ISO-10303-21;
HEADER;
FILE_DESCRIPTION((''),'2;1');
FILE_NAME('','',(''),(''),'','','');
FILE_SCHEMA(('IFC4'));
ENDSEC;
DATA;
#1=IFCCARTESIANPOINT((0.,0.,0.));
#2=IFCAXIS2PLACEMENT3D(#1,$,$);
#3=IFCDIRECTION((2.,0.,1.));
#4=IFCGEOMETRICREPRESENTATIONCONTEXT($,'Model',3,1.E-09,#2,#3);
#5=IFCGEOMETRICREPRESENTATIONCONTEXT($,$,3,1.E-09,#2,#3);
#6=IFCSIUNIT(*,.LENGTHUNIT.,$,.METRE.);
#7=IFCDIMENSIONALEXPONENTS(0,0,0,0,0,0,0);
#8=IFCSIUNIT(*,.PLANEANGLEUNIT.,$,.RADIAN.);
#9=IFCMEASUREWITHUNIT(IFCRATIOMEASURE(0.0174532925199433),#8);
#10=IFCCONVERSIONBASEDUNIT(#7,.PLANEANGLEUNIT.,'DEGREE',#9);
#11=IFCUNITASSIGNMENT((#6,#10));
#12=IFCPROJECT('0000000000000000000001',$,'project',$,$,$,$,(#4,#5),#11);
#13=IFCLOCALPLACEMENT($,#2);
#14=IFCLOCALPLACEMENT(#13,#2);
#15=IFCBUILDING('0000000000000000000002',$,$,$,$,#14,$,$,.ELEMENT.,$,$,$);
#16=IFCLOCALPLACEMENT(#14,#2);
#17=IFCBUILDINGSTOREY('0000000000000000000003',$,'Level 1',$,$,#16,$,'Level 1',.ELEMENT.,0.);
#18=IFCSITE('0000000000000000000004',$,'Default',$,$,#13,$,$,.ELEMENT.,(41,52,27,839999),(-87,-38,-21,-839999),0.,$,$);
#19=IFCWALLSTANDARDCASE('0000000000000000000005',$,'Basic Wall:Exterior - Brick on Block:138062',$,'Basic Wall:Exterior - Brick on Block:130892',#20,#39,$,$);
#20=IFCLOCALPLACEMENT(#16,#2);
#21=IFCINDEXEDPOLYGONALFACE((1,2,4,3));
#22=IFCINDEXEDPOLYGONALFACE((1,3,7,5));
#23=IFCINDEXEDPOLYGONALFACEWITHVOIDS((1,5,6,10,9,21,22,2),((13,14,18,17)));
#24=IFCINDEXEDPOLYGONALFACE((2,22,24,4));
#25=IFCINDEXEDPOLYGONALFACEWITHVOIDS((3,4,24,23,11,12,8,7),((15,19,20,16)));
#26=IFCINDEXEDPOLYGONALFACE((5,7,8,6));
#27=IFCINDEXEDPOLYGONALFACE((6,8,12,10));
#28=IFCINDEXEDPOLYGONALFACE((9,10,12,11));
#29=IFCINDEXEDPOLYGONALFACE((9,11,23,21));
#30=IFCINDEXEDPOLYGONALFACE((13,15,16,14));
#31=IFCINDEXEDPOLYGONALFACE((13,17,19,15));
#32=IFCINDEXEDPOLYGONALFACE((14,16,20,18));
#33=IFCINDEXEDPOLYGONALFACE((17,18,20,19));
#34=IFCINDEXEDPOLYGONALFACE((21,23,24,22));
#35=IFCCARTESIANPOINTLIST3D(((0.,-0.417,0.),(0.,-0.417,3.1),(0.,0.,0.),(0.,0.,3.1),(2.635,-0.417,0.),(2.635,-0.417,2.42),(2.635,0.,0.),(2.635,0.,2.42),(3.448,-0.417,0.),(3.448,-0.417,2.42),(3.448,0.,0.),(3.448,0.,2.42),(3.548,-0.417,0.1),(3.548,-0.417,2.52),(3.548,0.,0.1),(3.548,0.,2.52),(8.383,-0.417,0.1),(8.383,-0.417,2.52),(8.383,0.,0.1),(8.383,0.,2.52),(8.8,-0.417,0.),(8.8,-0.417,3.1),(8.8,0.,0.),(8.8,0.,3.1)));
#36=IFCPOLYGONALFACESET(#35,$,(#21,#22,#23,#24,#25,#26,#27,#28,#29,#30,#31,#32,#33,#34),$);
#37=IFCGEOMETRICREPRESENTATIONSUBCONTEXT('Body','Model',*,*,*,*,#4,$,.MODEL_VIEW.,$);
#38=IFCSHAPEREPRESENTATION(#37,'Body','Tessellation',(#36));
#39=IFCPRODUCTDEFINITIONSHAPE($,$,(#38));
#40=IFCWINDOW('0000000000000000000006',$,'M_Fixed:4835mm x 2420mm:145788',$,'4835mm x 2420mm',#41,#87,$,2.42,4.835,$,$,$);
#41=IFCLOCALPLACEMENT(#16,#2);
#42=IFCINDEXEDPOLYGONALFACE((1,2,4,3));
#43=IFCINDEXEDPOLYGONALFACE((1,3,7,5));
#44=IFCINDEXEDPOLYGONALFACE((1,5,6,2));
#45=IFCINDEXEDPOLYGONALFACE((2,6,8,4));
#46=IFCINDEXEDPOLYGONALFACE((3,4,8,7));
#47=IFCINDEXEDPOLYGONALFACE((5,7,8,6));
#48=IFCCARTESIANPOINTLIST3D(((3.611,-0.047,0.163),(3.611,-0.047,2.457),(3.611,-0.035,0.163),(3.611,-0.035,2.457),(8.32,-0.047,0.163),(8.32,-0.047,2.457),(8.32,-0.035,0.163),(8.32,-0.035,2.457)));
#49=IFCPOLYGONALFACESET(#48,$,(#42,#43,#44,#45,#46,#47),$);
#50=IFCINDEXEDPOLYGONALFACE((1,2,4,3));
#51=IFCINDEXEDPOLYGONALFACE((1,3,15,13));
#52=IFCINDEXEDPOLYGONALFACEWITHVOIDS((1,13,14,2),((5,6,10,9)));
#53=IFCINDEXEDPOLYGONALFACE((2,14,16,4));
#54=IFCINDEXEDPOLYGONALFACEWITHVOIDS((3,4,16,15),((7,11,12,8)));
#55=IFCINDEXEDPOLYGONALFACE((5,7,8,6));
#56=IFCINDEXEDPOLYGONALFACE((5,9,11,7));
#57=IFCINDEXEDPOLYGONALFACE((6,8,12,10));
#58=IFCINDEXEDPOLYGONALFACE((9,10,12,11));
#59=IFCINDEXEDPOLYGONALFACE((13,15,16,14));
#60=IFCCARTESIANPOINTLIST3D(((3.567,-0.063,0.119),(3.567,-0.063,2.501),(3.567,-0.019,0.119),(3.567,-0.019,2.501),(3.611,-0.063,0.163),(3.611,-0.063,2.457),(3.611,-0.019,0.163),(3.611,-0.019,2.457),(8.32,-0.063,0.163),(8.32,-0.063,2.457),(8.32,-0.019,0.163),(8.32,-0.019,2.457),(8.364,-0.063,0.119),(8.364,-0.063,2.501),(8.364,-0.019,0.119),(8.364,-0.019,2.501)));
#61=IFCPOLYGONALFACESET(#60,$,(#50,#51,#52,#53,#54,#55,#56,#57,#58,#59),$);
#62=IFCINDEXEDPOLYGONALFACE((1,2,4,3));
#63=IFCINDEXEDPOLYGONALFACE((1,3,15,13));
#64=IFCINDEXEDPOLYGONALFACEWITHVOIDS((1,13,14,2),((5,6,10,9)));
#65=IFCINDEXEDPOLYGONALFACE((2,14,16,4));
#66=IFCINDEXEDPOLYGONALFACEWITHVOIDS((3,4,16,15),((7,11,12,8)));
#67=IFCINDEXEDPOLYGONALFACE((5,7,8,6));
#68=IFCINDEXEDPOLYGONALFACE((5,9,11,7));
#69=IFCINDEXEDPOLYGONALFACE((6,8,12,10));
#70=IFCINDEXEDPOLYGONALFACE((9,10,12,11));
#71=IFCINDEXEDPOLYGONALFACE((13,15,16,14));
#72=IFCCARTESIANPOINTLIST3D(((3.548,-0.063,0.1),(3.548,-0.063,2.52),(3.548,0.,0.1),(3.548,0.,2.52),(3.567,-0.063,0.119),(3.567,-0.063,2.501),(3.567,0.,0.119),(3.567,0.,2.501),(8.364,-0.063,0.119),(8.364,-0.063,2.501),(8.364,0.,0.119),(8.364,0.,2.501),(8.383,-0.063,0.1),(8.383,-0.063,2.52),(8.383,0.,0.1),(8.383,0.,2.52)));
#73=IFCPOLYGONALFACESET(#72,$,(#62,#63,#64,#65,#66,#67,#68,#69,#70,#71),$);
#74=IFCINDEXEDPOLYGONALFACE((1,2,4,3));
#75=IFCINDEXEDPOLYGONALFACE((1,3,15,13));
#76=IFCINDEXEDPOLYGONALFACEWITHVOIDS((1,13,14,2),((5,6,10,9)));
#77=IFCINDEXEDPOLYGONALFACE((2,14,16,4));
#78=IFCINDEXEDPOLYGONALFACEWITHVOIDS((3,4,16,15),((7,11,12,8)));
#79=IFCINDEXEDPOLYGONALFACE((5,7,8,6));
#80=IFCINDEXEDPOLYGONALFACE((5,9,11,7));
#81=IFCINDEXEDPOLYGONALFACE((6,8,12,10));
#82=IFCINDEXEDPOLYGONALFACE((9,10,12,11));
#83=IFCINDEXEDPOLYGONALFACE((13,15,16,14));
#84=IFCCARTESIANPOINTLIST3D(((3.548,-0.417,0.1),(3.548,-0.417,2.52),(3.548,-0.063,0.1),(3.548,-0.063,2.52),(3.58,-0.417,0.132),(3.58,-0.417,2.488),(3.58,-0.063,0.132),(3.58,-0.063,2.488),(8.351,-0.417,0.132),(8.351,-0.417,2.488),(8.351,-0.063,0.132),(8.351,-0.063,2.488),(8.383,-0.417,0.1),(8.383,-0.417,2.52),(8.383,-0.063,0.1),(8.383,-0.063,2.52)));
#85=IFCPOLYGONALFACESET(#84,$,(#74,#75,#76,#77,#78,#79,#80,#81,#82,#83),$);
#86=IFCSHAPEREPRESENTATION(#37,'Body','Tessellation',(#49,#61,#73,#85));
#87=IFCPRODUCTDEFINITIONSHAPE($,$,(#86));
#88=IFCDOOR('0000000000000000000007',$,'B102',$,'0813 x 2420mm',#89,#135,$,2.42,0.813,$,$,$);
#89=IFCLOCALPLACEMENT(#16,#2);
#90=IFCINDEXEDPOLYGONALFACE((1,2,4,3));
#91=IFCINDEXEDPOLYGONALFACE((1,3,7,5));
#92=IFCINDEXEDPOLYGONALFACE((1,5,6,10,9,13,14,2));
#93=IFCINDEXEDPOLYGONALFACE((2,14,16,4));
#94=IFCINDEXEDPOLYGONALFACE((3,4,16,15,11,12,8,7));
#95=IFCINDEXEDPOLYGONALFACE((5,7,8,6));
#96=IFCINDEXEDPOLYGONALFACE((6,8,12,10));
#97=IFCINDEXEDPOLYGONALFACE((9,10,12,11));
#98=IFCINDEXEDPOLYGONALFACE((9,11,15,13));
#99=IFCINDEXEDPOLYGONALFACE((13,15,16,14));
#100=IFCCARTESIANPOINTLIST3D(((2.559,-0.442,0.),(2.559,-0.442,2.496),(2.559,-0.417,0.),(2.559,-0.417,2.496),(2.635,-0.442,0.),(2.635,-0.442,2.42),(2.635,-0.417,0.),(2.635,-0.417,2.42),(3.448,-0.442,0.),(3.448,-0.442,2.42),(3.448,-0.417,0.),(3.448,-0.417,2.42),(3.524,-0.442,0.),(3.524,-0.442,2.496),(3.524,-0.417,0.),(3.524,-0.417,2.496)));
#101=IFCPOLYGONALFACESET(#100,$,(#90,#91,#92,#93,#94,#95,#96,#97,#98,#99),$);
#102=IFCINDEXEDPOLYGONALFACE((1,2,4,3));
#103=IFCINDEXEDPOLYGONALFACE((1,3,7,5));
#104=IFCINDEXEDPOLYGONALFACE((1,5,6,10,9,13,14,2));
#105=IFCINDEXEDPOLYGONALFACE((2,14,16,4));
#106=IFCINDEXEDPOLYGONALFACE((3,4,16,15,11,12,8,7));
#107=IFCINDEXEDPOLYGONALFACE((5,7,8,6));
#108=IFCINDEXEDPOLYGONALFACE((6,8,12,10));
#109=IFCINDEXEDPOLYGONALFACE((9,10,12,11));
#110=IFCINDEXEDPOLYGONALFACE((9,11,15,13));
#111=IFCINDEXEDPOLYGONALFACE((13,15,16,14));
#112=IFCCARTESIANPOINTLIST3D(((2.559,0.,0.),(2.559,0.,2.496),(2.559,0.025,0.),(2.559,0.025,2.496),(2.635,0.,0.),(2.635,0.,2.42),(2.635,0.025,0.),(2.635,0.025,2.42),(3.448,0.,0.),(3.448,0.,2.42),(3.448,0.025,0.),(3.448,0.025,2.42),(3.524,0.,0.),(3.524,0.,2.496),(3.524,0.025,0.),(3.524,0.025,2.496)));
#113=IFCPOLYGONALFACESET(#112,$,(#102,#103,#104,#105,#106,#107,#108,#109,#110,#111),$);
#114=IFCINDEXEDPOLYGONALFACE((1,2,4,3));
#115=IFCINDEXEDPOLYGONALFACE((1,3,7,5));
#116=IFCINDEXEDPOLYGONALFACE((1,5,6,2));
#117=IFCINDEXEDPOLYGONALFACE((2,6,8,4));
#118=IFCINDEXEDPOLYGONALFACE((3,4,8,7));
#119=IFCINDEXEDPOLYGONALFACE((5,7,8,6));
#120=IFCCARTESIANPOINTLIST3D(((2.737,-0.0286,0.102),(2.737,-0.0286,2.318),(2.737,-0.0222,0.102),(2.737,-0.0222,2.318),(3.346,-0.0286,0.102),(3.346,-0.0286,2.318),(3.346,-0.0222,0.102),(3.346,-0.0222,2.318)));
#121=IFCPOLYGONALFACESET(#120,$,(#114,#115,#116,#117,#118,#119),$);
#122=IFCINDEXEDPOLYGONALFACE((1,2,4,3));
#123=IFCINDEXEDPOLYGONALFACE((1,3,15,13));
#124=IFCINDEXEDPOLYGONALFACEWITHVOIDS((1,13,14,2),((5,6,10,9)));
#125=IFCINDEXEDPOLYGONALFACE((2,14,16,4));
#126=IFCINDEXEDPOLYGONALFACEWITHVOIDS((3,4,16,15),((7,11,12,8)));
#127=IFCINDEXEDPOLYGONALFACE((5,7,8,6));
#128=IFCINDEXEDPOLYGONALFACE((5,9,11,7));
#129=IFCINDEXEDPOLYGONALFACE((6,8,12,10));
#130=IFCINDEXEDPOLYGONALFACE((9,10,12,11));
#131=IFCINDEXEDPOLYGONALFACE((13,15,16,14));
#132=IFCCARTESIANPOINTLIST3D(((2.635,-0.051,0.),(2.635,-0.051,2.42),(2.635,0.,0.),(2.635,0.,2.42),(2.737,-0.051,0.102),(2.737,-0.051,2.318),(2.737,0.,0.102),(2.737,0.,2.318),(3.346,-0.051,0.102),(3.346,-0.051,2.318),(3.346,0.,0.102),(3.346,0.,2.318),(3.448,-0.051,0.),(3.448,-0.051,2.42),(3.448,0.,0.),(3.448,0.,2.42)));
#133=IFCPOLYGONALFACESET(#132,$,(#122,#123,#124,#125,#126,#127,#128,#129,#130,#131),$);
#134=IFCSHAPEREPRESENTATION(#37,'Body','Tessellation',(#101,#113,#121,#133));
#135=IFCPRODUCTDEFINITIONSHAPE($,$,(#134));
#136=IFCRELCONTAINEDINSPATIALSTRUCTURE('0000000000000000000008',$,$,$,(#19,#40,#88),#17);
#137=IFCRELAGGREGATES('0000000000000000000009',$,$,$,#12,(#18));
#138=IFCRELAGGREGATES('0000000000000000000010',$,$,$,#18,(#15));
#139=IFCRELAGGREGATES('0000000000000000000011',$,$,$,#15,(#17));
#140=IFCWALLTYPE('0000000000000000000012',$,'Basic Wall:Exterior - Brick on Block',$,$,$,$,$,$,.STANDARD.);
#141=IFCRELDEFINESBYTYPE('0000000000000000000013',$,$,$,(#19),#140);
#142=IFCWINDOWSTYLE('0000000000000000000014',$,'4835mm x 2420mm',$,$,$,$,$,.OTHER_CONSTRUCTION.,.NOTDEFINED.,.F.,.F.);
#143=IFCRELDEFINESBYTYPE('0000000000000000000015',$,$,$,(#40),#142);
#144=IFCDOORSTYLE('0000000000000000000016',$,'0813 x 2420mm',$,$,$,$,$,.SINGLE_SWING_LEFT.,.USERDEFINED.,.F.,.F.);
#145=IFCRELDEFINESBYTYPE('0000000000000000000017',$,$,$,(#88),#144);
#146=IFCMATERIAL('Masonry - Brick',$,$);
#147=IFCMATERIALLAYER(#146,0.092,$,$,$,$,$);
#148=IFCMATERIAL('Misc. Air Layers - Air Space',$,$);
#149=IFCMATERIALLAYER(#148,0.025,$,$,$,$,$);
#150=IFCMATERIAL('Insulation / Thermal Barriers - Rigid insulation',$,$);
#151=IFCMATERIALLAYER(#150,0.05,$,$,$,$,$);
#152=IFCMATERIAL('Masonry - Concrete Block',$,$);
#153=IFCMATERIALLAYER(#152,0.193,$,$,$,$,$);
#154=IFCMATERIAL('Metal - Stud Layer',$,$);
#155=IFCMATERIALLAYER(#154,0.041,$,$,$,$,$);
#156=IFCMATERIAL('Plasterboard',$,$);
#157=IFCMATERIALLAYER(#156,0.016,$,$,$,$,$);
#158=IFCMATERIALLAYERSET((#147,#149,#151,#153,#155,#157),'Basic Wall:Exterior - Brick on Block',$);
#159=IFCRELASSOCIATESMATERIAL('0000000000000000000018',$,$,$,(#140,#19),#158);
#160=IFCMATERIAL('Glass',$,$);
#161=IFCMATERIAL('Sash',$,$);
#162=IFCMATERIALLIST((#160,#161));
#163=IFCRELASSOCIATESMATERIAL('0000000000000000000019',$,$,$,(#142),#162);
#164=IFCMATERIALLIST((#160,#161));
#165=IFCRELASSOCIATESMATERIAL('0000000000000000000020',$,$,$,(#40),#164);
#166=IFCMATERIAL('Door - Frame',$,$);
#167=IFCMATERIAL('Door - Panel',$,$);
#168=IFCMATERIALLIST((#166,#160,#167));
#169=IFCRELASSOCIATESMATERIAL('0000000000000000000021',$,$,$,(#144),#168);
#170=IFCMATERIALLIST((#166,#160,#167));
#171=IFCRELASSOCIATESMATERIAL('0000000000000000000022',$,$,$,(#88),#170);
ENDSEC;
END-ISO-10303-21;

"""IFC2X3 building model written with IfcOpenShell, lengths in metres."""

from ifc_helpers import new_model, entity, si_unit, converted_unit, direction, frame, frame_2d, origin, origin_2d_with_axis, place, context, subcontext, project, spatial, polyline, rectangle, outline, extrude, source, transform, mapped, material, material_list, layer, layer_set, layer_usage, type_object, type_shapes, element, fill, save


model = new_model("IFC2X3")

# Units and contexts
model_context = context("Model", 3, precision=1e-09, world=origin(), true_north=direction((2.0, 0.0, 1.0)))
context_of_model = context(None, 3, precision=1e-09, world=origin(), true_north=direction((2.0, 0.0, 1.0)))
body_context = subcontext(model_context, "Body", "Model", "MODEL_VIEW")
ifc_project = project(units=[si_unit("LENGTHUNIT", "METRE"), converted_unit("PLANEANGLEUNIT", "DEGREE", entity("IfcRatioMeasure", 0.0174532925199433), si_unit("PLANEANGLEUNIT", "RADIAN"), dimensions=[0, 0, 0, 0, 0, 0, 0])], contexts=[model_context, context_of_model])

# Site, building, storey
site_placement = place(None, origin())
site = spatial("IfcSite", under=ifc_project, at=site_placement, Name="Default", CompositionType="ELEMENT", RefLatitude=(41, 52, 27, 839999), RefLongitude=(-87, -38, -21, -839999), RefElevation=0.0)
building_placement = place(site_placement, origin())
building = spatial("IfcBuilding", under=site, at=building_placement, CompositionType="ELEMENT")
storey_placement = place(building_placement, origin())
storey = spatial("IfcBuildingStorey", under=building, at=storey_placement, Name="Level 1", LongName="Level 1", CompositionType="ELEMENT", Elevation=0.0)

# Wall, openings, window, door
ifc_material_1 = material(Name="Masonry - Brick")
ifc_layer_1 = layer(ifc_material_1, 0.092)
ifc_material_2 = material(Name="Misc. Air Layers - Air Space")
ifc_layer_2 = layer(ifc_material_2, 0.025)
ifc_material_3 = material(Name="Insulation / Thermal Barriers - Rigid insulation")
ifc_layer_3 = layer(ifc_material_3, 0.05)
ifc_material_4 = material(Name="Masonry - Concrete Block")
ifc_layer_4 = layer(ifc_material_4, 0.193)
ifc_material_5 = material(Name="Metal - Stud Layer")
ifc_layer_5 = layer(ifc_material_5, 0.041)
ifc_material_6 = material(Name="Plasterboard")
ifc_layer_6 = layer(ifc_material_6, 0.016)
ifc_layer_set_1 = layer_set([ifc_layer_1, ifc_layer_2, ifc_layer_3, ifc_layer_4, ifc_layer_5, ifc_layer_6], Name="Basic Wall:Exterior - Brick on Block")
ifc_layer_usage_1 = layer_usage(ifc_layer_set_1, "AXIS2", "NEGATIVE", 0.2085)
wall_type_1 = type_object("IfcWallType", Name="Basic Wall:Exterior - Brick on Block", PredefinedType="STANDARD", material=ifc_layer_set_1)
wall_1_placement = place(storey_placement, frame((0.0, -0.2085, 0.0)))
wall_1 = element("IfcWallStandardCase", 1, at=wall_1_placement, inside=storey, type_object=wall_type_1, material=ifc_layer_usage_1, Name="Basic Wall:Exterior - Brick on Block:138062", ObjectType="Basic Wall:Exterior - Brick on Block:130892", context=body_context, shape_type="SweptSolid", body=[
    extrude(rectangle(XDim=8.8, YDim=0.417, at=frame_2d((4.4, 0.0), x_axis=(-1.0, 0.0))), origin(), (0.0, 0.0, 1.0), 3.1),
])
opening_1_placement = place(wall_1_placement, frame((3.548, -0.2085, 0.1)))
opening_1 = element("IfcOpeningElement", 2, at=opening_1_placement, cuts=wall_1, ObjectType="Opening", context=body_context, shape_type="SweptSolid", body=[
    extrude(rectangle(XDim=2.42, YDim=4.835, at=frame_2d((1.21, 2.4175), x_axis=(1.0, 0.0))), frame((0.0, 0.0, 0.0), z_axis=(0.0, 1.0, 0.0), x_axis=(0.0, 0.0, 1.0)), (0.0, 0.0, 1.0), 0.417),
])
opening_2_placement = place(wall_1_placement, frame((2.635, -0.2085, 0.0)))
opening_2 = element("IfcOpeningElement", 3, at=opening_2_placement, cuts=wall_1, ObjectType="Opening", context=body_context, shape_type="SweptSolid", body=[
    extrude(rectangle(XDim=0.813, YDim=2.42, at=frame_2d((1.21, 0.4065), x_axis=(0.0, -1.0))), frame((0.0, 0.0, 0.0), z_axis=(0.0, 1.0, 0.0), x_axis=(0.0, 0.0, 1.0)), (0.0, 0.0, 1.0), 0.417),
])
ifc_material_7 = material(Name="Glass")
ifc_material_8 = material(Name="Sash")
ifc_material_list_1 = material_list([ifc_material_7, ifc_material_8])
ifc_material_list_2 = material_list([ifc_material_7, ifc_material_8])
window_style_1 = type_object("IfcWindowStyle", Name="4835mm x 2420mm", ConstructionType="OTHER_CONSTRUCTION", OperationType="NOTDEFINED", ParameterTakesPrecedence=False, Sizeable=False, material=ifc_material_list_2)
shared_shape_1 = source(origin(), body_context, "Body", "SweptSolid", [
    extrude(rectangle(XDim=0.012, YDim=4.709, at=origin_2d_with_axis()), frame((2.4175, 0.376, 0.063), z_axis=(0.0, 0.0, 1.0), x_axis=(0.0, -1.0, 0.0)), (0.0, 0.0, 1.0), 2.294),
    extrude(outline(polyline([(-2.3985, -1.191), (2.3985, -1.191), (2.3985, 1.191), (-2.3985, 1.191), (-2.3985, -1.191)]), holes=[polyline([(-2.3545, -1.147), (-2.3545, 1.147), (2.3545, 1.147), (2.3545, -1.147), (-2.3545, -1.147)])]), frame((2.4175, 0.354, 1.21), z_axis=(0.0, 1.0, 0.0), x_axis=(1.0, 0.0, 0.0)), (0.0, 0.0, 1.0), 0.044),
    extrude(outline(polyline([(-2.4175, -1.21), (2.4175, -1.21), (2.4175, 1.21), (-2.4175, 1.21), (-2.4175, -1.21)]), holes=[polyline([(-2.3985, -1.191), (-2.3985, 1.191), (2.3985, 1.191), (2.3985, -1.191), (-2.3985, -1.191)])]), frame((2.4175, 0.354, 1.21), z_axis=(0.0, 1.0, 0.0), x_axis=(1.0, 0.0, 0.0)), (0.0, 0.0, 1.0), 0.063),
    extrude(outline(polyline([(-2.4175, -1.21), (2.4175, -1.21), (2.4175, 1.21), (-2.4175, 1.21), (-2.4175, -1.21)]), holes=[polyline([(-2.3855, -1.178), (-2.3855, 1.178), (2.3855, 1.178), (2.3855, -1.178), (-2.3855, -1.178)])]), frame((2.4175, 0.0, 1.21), z_axis=(0.0, 1.0, 0.0), x_axis=(1.0, 0.0, 0.0)), (0.0, 0.0, 1.0), 0.354),
])
type_shapes(window_style_1, [shared_shape_1])
window_1_placement = place(opening_1_placement, origin())
window_1 = element("IfcWindow", 4, at=window_1_placement, inside=storey, type_object=window_style_1, material=ifc_material_list_1, Name="M_Fixed:4835mm x 2420mm:145788", ObjectType="4835mm x 2420mm", OverallHeight=2.42, OverallWidth=4.835, context=body_context, shape_type="MappedRepresentation", body=[
    mapped(shared_shape_1, transform((0.0, 0.0, 0.0), scale=1.0)),
])
fill(opening_1, window_1)
ifc_material_9 = material(Name="Door - Frame")
ifc_material_10 = material(Name="Door - Panel")
ifc_material_list_3 = material_list([ifc_material_9, ifc_material_7, ifc_material_10])
ifc_material_list_4 = material_list([ifc_material_9, ifc_material_7, ifc_material_10])
door_style_1 = type_object("IfcDoorStyle", Name="0813 x 2420mm", ConstructionType="USERDEFINED", OperationType="SINGLE_SWING_LEFT", ParameterTakesPrecedence=False, Sizeable=False, material=ifc_material_list_4)
shared_shape_2 = source(origin(), body_context, "Body", "SweptSolid", [
    extrude(outline(polyline([(-0.4065, -1.191), (-0.4065, 1.229), (-0.4825, 1.229), (-0.4825, -1.267), (0.4825, -1.267), (0.4825, 1.229), (0.4065, 1.229), (0.4065, -1.191), (-0.4065, -1.191)])), frame((0.4065, 0.0, 1.229), z_axis=(0.0, 1.0, 0.0), x_axis=(1.0, 0.0, 0.0)), (0.0, 0.0, -1.0), 0.025),
    extrude(outline(polyline([(-0.4065, -1.191), (-0.4065, 1.229), (-0.4825, 1.229), (-0.4825, -1.267), (0.4825, -1.267), (0.4825, 1.229), (0.4065, 1.229), (0.4065, -1.191), (-0.4065, -1.191)])), frame((0.4065, 0.442, 1.229), z_axis=(0.0, 1.0, 0.0), x_axis=(1.0, 0.0, 0.0)), (0.0, 0.0, -1.0), 0.025),
    extrude(rectangle(XDim=0.609, YDim=0.0064, at=frame_2d((0.0, 0.0), x_axis=(1.0, 0.0))), frame((0.4065, 0.3916, 0.102)), (0.0, 0.0, 1.0), 2.216),
    extrude(outline(polyline([(-1.21, -0.4065), (1.21, -0.4065), (1.21, 0.4065), (-1.21, 0.4065), (-1.21, -0.4065)]), holes=[polyline([(-1.108, 0.3045), (1.108, 0.3045), (1.108, -0.3045), (-1.108, -0.3045), (-1.108, 0.3045)])]), frame((0.4065, 0.417, 1.21), z_axis=(0.0, -1.0, 0.0), x_axis=(0.0, 0.0, -1.0)), (0.0, 0.0, 1.0), 0.051),
])
type_shapes(door_style_1, [shared_shape_2])
door_1_placement = place(opening_2_placement, origin())
door_1 = element("IfcDoor", 5, at=door_1_placement, inside=storey, type_object=door_style_1, material=ifc_material_list_3, Name="B102", ObjectType="0813 x 2420mm", OverallHeight=2.42, OverallWidth=0.813, context=body_context, shape_type="MappedRepresentation", body=[
    mapped(shared_shape_2, transform((0.0, 0.0, 0.0), scale=1.0)),
])
fill(opening_2, door_1)

save(model, "model.ifc")
